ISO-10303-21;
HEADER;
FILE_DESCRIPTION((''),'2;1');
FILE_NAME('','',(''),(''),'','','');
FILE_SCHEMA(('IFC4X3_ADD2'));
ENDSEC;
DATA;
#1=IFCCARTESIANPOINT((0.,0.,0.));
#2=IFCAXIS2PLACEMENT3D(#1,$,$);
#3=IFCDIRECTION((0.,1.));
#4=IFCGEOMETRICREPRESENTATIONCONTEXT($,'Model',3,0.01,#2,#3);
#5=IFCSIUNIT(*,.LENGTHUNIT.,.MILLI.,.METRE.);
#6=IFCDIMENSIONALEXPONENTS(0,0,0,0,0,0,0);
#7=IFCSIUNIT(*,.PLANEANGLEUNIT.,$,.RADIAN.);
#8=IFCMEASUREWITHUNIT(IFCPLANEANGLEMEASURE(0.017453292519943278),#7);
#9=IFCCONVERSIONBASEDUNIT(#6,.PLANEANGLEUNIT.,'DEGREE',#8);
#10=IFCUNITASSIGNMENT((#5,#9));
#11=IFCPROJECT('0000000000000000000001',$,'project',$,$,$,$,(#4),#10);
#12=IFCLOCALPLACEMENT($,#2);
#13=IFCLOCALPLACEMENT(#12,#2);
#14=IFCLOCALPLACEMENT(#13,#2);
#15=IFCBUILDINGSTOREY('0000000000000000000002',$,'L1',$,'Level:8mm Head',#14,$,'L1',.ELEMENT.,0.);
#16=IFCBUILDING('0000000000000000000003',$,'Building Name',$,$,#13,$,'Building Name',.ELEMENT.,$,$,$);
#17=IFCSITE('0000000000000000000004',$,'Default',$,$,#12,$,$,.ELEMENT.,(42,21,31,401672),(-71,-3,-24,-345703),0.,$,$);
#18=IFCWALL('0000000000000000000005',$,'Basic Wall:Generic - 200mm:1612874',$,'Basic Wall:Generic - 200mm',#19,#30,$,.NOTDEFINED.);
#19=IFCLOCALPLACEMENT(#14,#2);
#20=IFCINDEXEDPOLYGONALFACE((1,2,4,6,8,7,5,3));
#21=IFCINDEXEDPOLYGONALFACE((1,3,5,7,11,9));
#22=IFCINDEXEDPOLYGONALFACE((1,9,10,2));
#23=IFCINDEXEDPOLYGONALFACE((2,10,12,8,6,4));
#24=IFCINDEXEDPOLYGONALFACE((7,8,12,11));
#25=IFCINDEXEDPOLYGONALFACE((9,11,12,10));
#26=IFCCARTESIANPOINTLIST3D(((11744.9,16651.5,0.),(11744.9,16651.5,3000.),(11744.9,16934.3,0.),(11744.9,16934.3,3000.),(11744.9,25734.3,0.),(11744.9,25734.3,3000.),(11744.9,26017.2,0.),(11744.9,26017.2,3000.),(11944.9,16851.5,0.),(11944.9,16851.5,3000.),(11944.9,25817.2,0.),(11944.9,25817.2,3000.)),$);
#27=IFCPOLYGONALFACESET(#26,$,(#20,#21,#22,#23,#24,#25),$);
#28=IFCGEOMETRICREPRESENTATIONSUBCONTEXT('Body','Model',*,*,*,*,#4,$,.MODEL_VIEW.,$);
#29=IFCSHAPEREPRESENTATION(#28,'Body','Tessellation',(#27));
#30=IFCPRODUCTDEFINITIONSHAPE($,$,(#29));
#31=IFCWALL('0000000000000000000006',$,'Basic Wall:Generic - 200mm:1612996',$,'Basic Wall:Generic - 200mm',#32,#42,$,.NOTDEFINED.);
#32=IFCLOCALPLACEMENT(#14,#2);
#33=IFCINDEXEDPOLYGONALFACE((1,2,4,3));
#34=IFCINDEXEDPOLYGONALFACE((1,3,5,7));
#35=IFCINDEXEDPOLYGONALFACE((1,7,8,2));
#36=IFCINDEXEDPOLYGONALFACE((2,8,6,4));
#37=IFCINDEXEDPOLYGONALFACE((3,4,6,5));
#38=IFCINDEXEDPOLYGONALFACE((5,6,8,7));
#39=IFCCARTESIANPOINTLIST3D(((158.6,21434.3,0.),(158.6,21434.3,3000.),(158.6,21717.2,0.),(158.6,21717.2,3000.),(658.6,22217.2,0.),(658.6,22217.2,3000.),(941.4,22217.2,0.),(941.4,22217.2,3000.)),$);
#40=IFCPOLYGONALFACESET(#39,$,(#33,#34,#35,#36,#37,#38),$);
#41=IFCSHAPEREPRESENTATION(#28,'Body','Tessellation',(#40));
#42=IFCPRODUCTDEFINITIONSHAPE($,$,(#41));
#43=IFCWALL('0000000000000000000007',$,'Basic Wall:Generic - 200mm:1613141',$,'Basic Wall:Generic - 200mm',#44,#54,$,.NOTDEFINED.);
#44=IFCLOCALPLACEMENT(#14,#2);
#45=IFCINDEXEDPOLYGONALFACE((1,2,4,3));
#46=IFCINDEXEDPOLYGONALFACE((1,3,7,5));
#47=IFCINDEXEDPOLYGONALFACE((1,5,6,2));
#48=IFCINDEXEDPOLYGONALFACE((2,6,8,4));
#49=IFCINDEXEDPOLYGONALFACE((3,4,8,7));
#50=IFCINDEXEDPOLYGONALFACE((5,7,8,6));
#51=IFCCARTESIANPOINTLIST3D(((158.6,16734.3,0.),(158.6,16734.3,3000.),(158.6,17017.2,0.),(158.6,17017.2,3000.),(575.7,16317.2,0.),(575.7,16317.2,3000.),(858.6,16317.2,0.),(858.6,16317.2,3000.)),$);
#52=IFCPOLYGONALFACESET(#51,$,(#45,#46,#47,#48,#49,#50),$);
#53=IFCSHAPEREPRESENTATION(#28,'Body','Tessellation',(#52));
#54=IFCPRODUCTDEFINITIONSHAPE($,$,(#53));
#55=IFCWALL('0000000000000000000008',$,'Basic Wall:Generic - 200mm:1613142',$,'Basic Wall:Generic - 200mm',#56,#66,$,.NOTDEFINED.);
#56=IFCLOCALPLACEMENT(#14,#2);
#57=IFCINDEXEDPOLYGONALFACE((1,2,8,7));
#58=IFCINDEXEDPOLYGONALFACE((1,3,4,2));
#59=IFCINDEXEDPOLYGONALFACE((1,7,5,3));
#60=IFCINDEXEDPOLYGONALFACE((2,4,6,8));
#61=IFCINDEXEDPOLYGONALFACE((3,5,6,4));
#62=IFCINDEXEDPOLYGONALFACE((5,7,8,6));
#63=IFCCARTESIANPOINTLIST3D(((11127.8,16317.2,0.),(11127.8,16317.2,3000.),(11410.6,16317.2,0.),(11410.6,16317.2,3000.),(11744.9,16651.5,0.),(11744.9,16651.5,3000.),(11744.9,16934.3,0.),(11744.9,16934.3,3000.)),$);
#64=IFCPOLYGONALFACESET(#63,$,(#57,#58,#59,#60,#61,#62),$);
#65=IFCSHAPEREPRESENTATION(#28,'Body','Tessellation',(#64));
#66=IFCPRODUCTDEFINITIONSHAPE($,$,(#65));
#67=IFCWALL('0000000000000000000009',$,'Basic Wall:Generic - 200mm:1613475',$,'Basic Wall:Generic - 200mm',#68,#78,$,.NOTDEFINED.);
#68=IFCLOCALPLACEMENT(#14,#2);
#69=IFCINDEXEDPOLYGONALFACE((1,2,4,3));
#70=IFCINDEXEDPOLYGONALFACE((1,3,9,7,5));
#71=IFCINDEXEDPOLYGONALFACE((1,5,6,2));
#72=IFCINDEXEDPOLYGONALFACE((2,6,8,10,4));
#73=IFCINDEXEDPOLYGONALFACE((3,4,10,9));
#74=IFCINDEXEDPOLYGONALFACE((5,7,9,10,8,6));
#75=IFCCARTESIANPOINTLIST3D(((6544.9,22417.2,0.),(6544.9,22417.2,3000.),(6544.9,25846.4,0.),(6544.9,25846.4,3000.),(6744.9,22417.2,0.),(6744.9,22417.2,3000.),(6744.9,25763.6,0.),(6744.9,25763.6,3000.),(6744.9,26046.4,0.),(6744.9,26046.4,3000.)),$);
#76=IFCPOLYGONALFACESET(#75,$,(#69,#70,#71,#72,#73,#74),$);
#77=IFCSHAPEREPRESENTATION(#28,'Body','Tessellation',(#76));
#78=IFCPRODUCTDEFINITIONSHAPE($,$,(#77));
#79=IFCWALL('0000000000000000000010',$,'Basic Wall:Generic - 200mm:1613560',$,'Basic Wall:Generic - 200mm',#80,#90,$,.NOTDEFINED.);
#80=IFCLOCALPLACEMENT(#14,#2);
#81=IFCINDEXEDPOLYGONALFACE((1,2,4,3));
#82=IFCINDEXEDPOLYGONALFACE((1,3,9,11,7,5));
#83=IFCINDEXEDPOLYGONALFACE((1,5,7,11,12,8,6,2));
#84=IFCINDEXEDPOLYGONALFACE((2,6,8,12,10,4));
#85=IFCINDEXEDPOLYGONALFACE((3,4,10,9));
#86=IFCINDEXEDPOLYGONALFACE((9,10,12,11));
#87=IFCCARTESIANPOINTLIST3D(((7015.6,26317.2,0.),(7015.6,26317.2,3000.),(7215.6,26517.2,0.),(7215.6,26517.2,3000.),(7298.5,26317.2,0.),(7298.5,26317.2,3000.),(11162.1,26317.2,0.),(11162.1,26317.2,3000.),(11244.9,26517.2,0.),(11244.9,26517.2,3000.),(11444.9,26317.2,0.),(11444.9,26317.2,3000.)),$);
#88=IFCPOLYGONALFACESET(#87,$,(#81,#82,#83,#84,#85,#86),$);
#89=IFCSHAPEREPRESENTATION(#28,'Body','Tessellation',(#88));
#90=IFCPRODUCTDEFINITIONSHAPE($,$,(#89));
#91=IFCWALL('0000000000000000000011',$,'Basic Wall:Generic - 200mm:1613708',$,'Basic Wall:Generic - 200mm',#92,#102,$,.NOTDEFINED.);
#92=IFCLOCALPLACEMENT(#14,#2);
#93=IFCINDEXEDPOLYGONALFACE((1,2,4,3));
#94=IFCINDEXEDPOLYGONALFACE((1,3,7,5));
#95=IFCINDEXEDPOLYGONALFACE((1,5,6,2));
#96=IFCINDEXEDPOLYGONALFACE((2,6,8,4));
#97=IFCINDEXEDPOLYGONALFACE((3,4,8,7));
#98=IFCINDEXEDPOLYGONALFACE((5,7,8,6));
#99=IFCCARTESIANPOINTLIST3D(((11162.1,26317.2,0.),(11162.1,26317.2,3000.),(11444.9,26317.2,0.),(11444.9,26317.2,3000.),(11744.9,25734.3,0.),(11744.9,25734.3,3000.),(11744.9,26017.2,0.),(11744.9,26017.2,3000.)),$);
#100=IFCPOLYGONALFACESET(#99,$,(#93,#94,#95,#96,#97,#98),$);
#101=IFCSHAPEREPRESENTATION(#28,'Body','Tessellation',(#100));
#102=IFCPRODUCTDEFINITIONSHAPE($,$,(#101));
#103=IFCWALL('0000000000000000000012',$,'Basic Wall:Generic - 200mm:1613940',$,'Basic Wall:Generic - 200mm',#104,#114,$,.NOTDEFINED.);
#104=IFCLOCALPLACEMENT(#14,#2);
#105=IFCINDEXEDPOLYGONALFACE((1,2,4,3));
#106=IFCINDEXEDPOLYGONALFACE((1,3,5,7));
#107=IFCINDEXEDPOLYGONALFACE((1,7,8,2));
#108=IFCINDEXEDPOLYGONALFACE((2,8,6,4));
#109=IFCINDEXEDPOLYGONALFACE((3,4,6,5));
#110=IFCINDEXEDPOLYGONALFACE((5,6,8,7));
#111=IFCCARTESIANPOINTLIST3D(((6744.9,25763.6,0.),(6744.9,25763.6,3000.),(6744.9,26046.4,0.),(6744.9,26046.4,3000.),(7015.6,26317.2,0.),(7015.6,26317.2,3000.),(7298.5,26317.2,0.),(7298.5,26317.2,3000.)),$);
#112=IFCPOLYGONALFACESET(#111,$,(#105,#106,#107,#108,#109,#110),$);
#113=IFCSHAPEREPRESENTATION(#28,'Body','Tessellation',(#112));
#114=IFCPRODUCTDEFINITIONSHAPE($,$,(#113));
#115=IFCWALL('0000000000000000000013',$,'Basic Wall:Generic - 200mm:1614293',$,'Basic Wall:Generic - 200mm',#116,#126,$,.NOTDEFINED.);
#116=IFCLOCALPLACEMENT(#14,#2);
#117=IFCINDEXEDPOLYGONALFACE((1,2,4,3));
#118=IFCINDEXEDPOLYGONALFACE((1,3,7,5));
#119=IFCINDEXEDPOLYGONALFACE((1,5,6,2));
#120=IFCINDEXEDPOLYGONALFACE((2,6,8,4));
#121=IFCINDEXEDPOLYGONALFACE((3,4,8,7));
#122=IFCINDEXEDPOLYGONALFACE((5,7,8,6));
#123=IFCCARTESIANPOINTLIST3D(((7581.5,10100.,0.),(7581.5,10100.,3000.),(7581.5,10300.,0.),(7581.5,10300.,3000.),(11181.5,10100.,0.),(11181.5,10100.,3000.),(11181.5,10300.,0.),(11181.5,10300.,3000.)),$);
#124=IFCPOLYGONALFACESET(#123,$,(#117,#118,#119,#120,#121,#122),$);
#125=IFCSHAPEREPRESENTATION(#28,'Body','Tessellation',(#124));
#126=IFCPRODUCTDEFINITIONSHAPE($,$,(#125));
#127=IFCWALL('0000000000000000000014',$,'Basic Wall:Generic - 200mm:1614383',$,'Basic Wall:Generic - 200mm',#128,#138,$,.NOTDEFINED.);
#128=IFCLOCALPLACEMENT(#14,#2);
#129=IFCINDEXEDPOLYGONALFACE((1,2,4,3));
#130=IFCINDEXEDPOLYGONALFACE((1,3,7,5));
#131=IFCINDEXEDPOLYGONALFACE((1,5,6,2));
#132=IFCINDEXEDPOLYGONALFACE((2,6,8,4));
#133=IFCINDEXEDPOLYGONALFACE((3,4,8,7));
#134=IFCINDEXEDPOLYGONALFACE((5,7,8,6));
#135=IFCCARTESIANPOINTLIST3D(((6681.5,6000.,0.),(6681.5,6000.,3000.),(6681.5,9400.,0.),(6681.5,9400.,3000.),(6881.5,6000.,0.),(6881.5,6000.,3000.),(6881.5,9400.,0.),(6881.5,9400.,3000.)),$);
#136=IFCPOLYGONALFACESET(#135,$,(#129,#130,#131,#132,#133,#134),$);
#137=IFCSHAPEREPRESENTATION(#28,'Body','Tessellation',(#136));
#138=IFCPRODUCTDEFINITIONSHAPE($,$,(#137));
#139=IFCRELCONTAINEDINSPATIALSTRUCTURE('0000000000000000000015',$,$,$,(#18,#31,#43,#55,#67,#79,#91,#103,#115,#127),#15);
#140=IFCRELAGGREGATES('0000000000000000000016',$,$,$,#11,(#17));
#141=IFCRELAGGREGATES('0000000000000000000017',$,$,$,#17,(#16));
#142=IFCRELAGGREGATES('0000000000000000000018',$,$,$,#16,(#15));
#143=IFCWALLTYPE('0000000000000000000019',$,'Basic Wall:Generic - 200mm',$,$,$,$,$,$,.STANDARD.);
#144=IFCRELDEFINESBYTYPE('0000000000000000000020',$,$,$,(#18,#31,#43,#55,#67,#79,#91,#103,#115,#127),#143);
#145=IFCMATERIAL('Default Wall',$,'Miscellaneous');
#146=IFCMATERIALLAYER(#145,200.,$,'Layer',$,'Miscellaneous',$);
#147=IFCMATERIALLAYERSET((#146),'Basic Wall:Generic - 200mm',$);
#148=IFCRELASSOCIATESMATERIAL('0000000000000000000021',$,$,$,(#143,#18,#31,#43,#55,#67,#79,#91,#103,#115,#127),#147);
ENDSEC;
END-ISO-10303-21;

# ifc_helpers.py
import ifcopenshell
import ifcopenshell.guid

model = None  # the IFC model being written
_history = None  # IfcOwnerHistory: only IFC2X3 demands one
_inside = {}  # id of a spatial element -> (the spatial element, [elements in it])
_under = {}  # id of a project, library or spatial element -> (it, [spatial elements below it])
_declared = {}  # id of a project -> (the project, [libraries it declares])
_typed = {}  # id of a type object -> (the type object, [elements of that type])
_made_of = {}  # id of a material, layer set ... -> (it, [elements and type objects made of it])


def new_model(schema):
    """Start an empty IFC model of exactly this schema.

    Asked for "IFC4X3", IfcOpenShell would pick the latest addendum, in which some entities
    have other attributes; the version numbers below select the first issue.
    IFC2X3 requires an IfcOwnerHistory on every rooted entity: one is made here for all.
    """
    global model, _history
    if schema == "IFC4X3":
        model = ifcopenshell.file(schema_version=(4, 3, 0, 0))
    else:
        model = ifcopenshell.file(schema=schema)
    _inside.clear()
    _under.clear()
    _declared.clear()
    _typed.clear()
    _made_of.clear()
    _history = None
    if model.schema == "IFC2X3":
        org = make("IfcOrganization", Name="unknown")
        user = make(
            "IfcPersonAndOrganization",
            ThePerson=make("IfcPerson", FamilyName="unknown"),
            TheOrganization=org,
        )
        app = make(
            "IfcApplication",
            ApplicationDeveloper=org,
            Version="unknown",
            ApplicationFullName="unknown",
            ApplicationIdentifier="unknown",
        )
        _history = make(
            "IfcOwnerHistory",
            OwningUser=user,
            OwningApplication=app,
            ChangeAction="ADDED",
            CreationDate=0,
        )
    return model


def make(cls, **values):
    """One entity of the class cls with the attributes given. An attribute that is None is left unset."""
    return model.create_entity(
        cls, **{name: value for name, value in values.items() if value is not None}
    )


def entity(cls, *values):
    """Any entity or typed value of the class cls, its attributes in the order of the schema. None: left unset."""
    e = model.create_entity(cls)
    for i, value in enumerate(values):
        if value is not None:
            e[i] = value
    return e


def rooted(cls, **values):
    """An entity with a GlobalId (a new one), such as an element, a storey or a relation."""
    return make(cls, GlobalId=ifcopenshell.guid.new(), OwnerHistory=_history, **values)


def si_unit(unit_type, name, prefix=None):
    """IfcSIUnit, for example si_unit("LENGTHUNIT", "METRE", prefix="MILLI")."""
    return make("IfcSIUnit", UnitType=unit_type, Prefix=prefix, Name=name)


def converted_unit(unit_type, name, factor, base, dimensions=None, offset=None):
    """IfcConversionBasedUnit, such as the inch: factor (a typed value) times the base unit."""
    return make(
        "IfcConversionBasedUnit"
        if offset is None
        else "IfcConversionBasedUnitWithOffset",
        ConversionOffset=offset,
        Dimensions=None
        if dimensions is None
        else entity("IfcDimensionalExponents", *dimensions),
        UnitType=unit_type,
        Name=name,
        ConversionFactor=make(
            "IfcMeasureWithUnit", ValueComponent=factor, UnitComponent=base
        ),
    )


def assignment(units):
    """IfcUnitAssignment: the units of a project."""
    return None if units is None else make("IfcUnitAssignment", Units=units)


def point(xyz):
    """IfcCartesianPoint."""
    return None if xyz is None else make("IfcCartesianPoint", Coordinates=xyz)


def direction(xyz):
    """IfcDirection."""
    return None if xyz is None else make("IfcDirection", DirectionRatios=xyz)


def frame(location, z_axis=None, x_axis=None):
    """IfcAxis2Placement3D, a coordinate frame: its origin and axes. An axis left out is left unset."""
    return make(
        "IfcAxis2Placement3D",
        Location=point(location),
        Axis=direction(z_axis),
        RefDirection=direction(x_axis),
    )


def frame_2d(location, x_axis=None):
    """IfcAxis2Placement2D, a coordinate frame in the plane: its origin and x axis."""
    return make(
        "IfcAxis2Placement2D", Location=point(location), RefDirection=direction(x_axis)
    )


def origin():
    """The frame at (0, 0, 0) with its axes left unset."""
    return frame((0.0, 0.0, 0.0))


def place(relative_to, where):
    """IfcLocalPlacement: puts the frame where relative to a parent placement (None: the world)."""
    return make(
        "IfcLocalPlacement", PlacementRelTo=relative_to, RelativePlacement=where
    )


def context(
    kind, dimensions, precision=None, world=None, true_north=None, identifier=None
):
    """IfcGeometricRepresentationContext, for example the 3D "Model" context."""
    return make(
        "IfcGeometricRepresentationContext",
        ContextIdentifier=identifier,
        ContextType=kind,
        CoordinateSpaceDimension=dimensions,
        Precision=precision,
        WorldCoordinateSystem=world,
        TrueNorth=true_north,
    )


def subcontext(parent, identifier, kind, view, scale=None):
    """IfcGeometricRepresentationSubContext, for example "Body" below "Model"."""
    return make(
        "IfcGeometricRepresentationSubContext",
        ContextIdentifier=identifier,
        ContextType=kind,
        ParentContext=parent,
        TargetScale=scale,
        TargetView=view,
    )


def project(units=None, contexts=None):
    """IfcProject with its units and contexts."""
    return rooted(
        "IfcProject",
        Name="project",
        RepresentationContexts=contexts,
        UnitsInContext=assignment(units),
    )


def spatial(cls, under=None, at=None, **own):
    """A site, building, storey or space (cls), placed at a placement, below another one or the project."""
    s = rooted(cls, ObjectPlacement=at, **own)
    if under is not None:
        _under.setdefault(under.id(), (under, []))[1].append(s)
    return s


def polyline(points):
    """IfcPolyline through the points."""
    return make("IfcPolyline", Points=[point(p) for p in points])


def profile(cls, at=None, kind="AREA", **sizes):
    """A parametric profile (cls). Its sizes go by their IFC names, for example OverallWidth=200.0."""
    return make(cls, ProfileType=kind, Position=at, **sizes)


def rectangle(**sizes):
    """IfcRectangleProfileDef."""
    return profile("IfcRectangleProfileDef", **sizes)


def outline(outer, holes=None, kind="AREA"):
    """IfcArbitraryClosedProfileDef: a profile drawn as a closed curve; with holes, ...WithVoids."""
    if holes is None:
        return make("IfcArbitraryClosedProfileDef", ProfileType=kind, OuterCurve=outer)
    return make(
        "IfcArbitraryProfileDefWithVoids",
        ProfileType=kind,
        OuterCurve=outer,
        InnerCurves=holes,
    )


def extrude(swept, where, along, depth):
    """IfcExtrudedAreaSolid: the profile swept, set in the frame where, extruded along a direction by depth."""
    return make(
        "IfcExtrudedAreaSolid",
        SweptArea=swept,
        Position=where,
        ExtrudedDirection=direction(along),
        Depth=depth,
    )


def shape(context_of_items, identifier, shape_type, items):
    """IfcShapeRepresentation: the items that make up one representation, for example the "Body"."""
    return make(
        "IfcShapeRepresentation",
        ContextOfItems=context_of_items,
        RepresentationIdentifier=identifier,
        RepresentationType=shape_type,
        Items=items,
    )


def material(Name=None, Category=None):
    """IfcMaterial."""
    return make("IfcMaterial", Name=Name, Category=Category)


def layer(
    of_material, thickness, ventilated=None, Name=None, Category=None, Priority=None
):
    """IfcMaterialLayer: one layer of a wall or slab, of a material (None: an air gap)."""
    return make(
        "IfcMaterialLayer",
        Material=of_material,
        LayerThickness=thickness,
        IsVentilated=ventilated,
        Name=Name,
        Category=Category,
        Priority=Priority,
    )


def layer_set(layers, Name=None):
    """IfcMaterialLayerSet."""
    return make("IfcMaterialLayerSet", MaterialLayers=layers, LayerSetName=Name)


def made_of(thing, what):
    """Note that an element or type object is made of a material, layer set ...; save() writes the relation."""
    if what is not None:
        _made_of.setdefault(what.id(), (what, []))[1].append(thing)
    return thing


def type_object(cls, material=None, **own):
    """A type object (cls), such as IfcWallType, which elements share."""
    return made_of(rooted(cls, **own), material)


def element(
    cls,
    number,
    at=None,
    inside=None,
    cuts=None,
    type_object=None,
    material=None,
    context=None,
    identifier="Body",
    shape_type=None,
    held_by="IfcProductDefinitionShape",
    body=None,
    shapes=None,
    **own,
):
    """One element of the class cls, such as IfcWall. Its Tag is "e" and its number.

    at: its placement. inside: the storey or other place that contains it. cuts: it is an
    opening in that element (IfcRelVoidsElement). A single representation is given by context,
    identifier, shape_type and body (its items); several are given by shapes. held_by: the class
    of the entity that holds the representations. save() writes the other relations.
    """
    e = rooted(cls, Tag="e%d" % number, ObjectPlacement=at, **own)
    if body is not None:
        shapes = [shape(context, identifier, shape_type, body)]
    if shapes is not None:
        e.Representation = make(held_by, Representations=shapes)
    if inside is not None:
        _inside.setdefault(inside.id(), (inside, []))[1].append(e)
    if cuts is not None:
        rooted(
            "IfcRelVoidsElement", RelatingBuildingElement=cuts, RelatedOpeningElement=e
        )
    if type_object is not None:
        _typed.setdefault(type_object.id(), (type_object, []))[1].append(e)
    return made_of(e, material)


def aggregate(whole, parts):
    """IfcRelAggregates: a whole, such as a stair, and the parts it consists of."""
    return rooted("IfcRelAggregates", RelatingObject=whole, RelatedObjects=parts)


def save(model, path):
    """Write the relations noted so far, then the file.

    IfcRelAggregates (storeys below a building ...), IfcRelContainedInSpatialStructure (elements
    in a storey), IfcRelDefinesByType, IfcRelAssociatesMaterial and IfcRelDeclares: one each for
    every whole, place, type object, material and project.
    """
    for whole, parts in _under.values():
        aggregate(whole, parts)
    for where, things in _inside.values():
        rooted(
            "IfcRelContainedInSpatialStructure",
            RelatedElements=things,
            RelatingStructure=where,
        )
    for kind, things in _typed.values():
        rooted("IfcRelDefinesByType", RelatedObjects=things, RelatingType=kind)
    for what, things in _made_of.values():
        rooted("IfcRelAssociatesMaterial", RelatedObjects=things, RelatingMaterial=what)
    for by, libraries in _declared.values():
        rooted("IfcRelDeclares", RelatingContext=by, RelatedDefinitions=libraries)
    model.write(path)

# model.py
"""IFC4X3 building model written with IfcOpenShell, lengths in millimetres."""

from ifc_helpers import new_model, entity, si_unit, converted_unit, direction, frame, frame_2d, origin, place, context, subcontext, project, spatial, polyline, rectangle, outline, extrude, material, layer, layer_set, type_object, element, save


model = new_model("IFC4X3")

# Units and contexts
model_context = context("Model", 3, precision=0.01, world=origin(), true_north=direction((0.0, 1.0)))
body_context = subcontext(model_context, "Body", "Model", "MODEL_VIEW")
ifc_project = project(units=[si_unit("LENGTHUNIT", "METRE", prefix="MILLI"), converted_unit("PLANEANGLEUNIT", "DEGREE", entity("IfcPlaneAngleMeasure", 0.017453292519943278), si_unit("PLANEANGLEUNIT", "RADIAN"), dimensions=[0, 0, 0, 0, 0, 0, 0])], contexts=[model_context])

# Site, building, storey
site_placement = place(None, origin())
site = spatial("IfcSite", under=ifc_project, at=site_placement, Name="Default", CompositionType="ELEMENT", RefLatitude=(42, 21, 31, 401672), RefLongitude=(-71, -3, -24, -345703), RefElevation=0.0)
building_placement = place(site_placement, origin())
building = spatial("IfcBuilding", under=site, at=building_placement, Name="Building Name", LongName="Building Name", CompositionType="ELEMENT")
storey_placement = place(building_placement, origin())
storey = spatial("IfcBuildingStorey", under=building, at=storey_placement, Name="L1", ObjectType="Level:8mm Head", LongName="L1", CompositionType="ELEMENT", Elevation=0.0)

# Walls
ifc_material = material(Name="Default Wall", Category="Miscellaneous")
ifc_layer = layer(ifc_material, 200.0, Name="Layer", Category="Miscellaneous")
ifc_layer_set = layer_set([ifc_layer], Name="Basic Wall:Generic - 200mm")
wall_type = type_object("IfcWallType", Name="Basic Wall:Generic - 200mm", PredefinedType="STANDARD", material=ifc_layer_set)
wall_1_placement = place(storey_placement, frame((11844.9, 16651.5, 0.0), z_axis=(0.0, 0.0, 1.0), x_axis=(0.0, 1.0, 0.0)))
element("IfcWall", 1, at=wall_1_placement, inside=storey, type_object=wall_type, material=ifc_layer_set, Name="Basic Wall:Generic - 200mm:1612874", ObjectType="Basic Wall:Generic - 200mm", PredefinedType="NOTDEFINED", context=body_context, shape_type="SweptSolid", body=[
    extrude(outline(polyline([(9165.7, -100.0), (9365.7, 100.0), (9082.8, 100.0), (282.8, 100.0), (0.0, 100.0), (200.0, -100.0), (9165.7, -100.0)])), origin(), (0.0, 0.0, 1.0), 3000.0),
])
wall_2_placement = place(storey_placement, frame((870.7, 22287.9, 0.0), z_axis=(0.0, 0.0, 1.0), x_axis=(-0.707107, -0.707107, 0.0)))
element("IfcWall", 2, at=wall_2_placement, inside=storey, type_object=wall_type, material=ifc_layer_set, Name="Basic Wall:Generic - 200mm:1612996", ObjectType="Basic Wall:Generic - 200mm", PredefinedType="NOTDEFINED", context=body_context, shape_type="SweptSolid", body=[
    extrude(outline(polyline([(907.1, -100.0), (1107.1, 100.0), (0.0, 100.0), (200.0, -100.0), (907.1, -100.0)])), origin(), (0.0, 0.0, 1.0), 3000.0),
])
wall_3_placement = place(storey_placement, frame((787.9, 16246.4, 0.0), z_axis=(0.0, 0.0, 1.0), x_axis=(-0.707107, 0.707107, 0.0)))
element("IfcWall", 3, at=wall_3_placement, inside=storey, type_object=wall_type, material=ifc_layer_set, Name="Basic Wall:Generic - 200mm:1613141", ObjectType="Basic Wall:Generic - 200mm", PredefinedType="NOTDEFINED", context=body_context, shape_type="SweptSolid", body=[
    extrude(outline(polyline([(989.9, -100.0), (789.9, 100.0), (200.0, 100.0), (0.0, -100.0), (989.9, -100.0)])), origin(), (0.0, 0.0, 1.0), 3000.0),
])
wall_4_placement = place(storey_placement, frame((11198.5, 16246.4, 0.0), z_axis=(0.0, 0.0, 1.0), x_axis=(0.707107, 0.707107, 0.0)))
element("IfcWall", 4, at=wall_4_placement, inside=storey, type_object=wall_type, material=ifc_layer_set, Name="Basic Wall:Generic - 200mm:1613142", ObjectType="Basic Wall:Generic - 200mm", PredefinedType="NOTDEFINED", context=body_context, shape_type="SweptSolid", body=[
    extrude(outline(polyline([(672.8, -100.0), (872.8, 100.0), (0.0, 100.0), (200.0, -100.0), (672.8, -100.0)])), origin(), (0.0, 0.0, 1.0), 3000.0),
])
wall_5_placement = place(storey_placement, frame((6644.9, 22417.2, 0.0), z_axis=(0.0, 0.0, 1.0), x_axis=(0.0, 1.0, 0.0)))
element("IfcWall", 5, at=wall_5_placement, inside=storey, type_object=wall_type, material=ifc_layer_set, Name="Basic Wall:Generic - 200mm:1613475", ObjectType="Basic Wall:Generic - 200mm", PredefinedType="NOTDEFINED", context=body_context, shape_type="SweptSolid", body=[
    extrude(outline(polyline([(3629.3, -100.0), (3429.3, 100.0), (0.0, 100.0), (0.0, -100.0), (3346.4, -100.0), (3629.3, -100.0)])), origin(), (0.0, 0.0, 1.0), 3000.0),
])
wall_6_placement = place(storey_placement, frame((7015.6, 26417.2, 0.0)))
element("IfcWall", 6, at=wall_6_placement, inside=storey, type_object=wall_type, material=ifc_layer_set, Name="Basic Wall:Generic - 200mm:1613560", ObjectType="Basic Wall:Generic - 200mm", PredefinedType="NOTDEFINED", context=body_context, shape_type="SweptSolid", body=[
    extrude(outline(polyline([(4429.3, -100.0), (4229.3, 100.0), (200.0, 100.0), (0.0, -100.0), (282.8, -100.0), (4146.4, -100.0), (4429.3, -100.0)])), origin(), (0.0, 0.0, 1.0), 3000.0),
])
wall_7_placement = place(storey_placement, frame((11232.8, 26387.9, 0.0), z_axis=(0.0, 0.0, 1.0), x_axis=(0.707107, -0.707107, 0.0)))
element("IfcWall", 7, at=wall_7_placement, inside=storey, type_object=wall_type, material=ifc_layer_set, Name="Basic Wall:Generic - 200mm:1613708", ObjectType="Basic Wall:Generic - 200mm", PredefinedType="NOTDEFINED", context=body_context, shape_type="SweptSolid", body=[
    extrude(outline(polyline([(824.3, -100.0), (624.3, 100.0), (200.0, 100.0), (0.0, -100.0), (824.3, -100.0)])), origin(), (0.0, 0.0, 1.0), 3000.0),
])
wall_8_placement = place(storey_placement, frame((7227.8, 26387.9, 0.0), z_axis=(0.0, 0.0, 1.0), x_axis=(-0.707107, -0.707107, 0.0)))
element("IfcWall", 8, at=wall_8_placement, inside=storey, type_object=wall_type, material=ifc_layer_set, Name="Basic Wall:Generic - 200mm:1613940", ObjectType="Basic Wall:Generic - 200mm", PredefinedType="NOTDEFINED", context=body_context, shape_type="SweptSolid", body=[
    extrude(outline(polyline([(582.8, -100.0), (782.8, 100.0), (0.0, 100.0), (200.0, -100.0), (582.8, -100.0)])), origin(), (0.0, 0.0, 1.0), 3000.0),
])
wall_9_placement = place(storey_placement, frame((11181.5, 10200.0, 0.0), z_axis=(0.0, 0.0, 1.0), x_axis=(-1.0, 0.0, 0.0)))
element("IfcWall", 9, at=wall_9_placement, inside=storey, type_object=wall_type, material=ifc_layer_set, Name="Basic Wall:Generic - 200mm:1614293", ObjectType="Basic Wall:Generic - 200mm", PredefinedType="NOTDEFINED", context=body_context, shape_type="SweptSolid", body=[
    extrude(rectangle(XDim=3600.0, YDim=200.0, at=frame_2d((1800.0, 0.0), x_axis=(-1.0, 0.0))), origin(), (0.0, 0.0, 1.0), 3000.0),
])
wall_10_placement = place(storey_placement, frame((6781.5, 9400.0, 0.0), z_axis=(0.0, 0.0, 1.0), x_axis=(0.0, -1.0, 0.0)))
element("IfcWall", 10, at=wall_10_placement, inside=storey, type_object=wall_type, material=ifc_layer_set, Name="Basic Wall:Generic - 200mm:1614383", ObjectType="Basic Wall:Generic - 200mm", PredefinedType="NOTDEFINED", context=body_context, shape_type="SweptSolid", body=[
    extrude(rectangle(XDim=3400.0, YDim=200.0, at=frame_2d((1700.0, 0.0), x_axis=(-1.0, 0.0))), origin(), (0.0, 0.0, 1.0), 3000.0),
])

save(model, "model.ifc")
